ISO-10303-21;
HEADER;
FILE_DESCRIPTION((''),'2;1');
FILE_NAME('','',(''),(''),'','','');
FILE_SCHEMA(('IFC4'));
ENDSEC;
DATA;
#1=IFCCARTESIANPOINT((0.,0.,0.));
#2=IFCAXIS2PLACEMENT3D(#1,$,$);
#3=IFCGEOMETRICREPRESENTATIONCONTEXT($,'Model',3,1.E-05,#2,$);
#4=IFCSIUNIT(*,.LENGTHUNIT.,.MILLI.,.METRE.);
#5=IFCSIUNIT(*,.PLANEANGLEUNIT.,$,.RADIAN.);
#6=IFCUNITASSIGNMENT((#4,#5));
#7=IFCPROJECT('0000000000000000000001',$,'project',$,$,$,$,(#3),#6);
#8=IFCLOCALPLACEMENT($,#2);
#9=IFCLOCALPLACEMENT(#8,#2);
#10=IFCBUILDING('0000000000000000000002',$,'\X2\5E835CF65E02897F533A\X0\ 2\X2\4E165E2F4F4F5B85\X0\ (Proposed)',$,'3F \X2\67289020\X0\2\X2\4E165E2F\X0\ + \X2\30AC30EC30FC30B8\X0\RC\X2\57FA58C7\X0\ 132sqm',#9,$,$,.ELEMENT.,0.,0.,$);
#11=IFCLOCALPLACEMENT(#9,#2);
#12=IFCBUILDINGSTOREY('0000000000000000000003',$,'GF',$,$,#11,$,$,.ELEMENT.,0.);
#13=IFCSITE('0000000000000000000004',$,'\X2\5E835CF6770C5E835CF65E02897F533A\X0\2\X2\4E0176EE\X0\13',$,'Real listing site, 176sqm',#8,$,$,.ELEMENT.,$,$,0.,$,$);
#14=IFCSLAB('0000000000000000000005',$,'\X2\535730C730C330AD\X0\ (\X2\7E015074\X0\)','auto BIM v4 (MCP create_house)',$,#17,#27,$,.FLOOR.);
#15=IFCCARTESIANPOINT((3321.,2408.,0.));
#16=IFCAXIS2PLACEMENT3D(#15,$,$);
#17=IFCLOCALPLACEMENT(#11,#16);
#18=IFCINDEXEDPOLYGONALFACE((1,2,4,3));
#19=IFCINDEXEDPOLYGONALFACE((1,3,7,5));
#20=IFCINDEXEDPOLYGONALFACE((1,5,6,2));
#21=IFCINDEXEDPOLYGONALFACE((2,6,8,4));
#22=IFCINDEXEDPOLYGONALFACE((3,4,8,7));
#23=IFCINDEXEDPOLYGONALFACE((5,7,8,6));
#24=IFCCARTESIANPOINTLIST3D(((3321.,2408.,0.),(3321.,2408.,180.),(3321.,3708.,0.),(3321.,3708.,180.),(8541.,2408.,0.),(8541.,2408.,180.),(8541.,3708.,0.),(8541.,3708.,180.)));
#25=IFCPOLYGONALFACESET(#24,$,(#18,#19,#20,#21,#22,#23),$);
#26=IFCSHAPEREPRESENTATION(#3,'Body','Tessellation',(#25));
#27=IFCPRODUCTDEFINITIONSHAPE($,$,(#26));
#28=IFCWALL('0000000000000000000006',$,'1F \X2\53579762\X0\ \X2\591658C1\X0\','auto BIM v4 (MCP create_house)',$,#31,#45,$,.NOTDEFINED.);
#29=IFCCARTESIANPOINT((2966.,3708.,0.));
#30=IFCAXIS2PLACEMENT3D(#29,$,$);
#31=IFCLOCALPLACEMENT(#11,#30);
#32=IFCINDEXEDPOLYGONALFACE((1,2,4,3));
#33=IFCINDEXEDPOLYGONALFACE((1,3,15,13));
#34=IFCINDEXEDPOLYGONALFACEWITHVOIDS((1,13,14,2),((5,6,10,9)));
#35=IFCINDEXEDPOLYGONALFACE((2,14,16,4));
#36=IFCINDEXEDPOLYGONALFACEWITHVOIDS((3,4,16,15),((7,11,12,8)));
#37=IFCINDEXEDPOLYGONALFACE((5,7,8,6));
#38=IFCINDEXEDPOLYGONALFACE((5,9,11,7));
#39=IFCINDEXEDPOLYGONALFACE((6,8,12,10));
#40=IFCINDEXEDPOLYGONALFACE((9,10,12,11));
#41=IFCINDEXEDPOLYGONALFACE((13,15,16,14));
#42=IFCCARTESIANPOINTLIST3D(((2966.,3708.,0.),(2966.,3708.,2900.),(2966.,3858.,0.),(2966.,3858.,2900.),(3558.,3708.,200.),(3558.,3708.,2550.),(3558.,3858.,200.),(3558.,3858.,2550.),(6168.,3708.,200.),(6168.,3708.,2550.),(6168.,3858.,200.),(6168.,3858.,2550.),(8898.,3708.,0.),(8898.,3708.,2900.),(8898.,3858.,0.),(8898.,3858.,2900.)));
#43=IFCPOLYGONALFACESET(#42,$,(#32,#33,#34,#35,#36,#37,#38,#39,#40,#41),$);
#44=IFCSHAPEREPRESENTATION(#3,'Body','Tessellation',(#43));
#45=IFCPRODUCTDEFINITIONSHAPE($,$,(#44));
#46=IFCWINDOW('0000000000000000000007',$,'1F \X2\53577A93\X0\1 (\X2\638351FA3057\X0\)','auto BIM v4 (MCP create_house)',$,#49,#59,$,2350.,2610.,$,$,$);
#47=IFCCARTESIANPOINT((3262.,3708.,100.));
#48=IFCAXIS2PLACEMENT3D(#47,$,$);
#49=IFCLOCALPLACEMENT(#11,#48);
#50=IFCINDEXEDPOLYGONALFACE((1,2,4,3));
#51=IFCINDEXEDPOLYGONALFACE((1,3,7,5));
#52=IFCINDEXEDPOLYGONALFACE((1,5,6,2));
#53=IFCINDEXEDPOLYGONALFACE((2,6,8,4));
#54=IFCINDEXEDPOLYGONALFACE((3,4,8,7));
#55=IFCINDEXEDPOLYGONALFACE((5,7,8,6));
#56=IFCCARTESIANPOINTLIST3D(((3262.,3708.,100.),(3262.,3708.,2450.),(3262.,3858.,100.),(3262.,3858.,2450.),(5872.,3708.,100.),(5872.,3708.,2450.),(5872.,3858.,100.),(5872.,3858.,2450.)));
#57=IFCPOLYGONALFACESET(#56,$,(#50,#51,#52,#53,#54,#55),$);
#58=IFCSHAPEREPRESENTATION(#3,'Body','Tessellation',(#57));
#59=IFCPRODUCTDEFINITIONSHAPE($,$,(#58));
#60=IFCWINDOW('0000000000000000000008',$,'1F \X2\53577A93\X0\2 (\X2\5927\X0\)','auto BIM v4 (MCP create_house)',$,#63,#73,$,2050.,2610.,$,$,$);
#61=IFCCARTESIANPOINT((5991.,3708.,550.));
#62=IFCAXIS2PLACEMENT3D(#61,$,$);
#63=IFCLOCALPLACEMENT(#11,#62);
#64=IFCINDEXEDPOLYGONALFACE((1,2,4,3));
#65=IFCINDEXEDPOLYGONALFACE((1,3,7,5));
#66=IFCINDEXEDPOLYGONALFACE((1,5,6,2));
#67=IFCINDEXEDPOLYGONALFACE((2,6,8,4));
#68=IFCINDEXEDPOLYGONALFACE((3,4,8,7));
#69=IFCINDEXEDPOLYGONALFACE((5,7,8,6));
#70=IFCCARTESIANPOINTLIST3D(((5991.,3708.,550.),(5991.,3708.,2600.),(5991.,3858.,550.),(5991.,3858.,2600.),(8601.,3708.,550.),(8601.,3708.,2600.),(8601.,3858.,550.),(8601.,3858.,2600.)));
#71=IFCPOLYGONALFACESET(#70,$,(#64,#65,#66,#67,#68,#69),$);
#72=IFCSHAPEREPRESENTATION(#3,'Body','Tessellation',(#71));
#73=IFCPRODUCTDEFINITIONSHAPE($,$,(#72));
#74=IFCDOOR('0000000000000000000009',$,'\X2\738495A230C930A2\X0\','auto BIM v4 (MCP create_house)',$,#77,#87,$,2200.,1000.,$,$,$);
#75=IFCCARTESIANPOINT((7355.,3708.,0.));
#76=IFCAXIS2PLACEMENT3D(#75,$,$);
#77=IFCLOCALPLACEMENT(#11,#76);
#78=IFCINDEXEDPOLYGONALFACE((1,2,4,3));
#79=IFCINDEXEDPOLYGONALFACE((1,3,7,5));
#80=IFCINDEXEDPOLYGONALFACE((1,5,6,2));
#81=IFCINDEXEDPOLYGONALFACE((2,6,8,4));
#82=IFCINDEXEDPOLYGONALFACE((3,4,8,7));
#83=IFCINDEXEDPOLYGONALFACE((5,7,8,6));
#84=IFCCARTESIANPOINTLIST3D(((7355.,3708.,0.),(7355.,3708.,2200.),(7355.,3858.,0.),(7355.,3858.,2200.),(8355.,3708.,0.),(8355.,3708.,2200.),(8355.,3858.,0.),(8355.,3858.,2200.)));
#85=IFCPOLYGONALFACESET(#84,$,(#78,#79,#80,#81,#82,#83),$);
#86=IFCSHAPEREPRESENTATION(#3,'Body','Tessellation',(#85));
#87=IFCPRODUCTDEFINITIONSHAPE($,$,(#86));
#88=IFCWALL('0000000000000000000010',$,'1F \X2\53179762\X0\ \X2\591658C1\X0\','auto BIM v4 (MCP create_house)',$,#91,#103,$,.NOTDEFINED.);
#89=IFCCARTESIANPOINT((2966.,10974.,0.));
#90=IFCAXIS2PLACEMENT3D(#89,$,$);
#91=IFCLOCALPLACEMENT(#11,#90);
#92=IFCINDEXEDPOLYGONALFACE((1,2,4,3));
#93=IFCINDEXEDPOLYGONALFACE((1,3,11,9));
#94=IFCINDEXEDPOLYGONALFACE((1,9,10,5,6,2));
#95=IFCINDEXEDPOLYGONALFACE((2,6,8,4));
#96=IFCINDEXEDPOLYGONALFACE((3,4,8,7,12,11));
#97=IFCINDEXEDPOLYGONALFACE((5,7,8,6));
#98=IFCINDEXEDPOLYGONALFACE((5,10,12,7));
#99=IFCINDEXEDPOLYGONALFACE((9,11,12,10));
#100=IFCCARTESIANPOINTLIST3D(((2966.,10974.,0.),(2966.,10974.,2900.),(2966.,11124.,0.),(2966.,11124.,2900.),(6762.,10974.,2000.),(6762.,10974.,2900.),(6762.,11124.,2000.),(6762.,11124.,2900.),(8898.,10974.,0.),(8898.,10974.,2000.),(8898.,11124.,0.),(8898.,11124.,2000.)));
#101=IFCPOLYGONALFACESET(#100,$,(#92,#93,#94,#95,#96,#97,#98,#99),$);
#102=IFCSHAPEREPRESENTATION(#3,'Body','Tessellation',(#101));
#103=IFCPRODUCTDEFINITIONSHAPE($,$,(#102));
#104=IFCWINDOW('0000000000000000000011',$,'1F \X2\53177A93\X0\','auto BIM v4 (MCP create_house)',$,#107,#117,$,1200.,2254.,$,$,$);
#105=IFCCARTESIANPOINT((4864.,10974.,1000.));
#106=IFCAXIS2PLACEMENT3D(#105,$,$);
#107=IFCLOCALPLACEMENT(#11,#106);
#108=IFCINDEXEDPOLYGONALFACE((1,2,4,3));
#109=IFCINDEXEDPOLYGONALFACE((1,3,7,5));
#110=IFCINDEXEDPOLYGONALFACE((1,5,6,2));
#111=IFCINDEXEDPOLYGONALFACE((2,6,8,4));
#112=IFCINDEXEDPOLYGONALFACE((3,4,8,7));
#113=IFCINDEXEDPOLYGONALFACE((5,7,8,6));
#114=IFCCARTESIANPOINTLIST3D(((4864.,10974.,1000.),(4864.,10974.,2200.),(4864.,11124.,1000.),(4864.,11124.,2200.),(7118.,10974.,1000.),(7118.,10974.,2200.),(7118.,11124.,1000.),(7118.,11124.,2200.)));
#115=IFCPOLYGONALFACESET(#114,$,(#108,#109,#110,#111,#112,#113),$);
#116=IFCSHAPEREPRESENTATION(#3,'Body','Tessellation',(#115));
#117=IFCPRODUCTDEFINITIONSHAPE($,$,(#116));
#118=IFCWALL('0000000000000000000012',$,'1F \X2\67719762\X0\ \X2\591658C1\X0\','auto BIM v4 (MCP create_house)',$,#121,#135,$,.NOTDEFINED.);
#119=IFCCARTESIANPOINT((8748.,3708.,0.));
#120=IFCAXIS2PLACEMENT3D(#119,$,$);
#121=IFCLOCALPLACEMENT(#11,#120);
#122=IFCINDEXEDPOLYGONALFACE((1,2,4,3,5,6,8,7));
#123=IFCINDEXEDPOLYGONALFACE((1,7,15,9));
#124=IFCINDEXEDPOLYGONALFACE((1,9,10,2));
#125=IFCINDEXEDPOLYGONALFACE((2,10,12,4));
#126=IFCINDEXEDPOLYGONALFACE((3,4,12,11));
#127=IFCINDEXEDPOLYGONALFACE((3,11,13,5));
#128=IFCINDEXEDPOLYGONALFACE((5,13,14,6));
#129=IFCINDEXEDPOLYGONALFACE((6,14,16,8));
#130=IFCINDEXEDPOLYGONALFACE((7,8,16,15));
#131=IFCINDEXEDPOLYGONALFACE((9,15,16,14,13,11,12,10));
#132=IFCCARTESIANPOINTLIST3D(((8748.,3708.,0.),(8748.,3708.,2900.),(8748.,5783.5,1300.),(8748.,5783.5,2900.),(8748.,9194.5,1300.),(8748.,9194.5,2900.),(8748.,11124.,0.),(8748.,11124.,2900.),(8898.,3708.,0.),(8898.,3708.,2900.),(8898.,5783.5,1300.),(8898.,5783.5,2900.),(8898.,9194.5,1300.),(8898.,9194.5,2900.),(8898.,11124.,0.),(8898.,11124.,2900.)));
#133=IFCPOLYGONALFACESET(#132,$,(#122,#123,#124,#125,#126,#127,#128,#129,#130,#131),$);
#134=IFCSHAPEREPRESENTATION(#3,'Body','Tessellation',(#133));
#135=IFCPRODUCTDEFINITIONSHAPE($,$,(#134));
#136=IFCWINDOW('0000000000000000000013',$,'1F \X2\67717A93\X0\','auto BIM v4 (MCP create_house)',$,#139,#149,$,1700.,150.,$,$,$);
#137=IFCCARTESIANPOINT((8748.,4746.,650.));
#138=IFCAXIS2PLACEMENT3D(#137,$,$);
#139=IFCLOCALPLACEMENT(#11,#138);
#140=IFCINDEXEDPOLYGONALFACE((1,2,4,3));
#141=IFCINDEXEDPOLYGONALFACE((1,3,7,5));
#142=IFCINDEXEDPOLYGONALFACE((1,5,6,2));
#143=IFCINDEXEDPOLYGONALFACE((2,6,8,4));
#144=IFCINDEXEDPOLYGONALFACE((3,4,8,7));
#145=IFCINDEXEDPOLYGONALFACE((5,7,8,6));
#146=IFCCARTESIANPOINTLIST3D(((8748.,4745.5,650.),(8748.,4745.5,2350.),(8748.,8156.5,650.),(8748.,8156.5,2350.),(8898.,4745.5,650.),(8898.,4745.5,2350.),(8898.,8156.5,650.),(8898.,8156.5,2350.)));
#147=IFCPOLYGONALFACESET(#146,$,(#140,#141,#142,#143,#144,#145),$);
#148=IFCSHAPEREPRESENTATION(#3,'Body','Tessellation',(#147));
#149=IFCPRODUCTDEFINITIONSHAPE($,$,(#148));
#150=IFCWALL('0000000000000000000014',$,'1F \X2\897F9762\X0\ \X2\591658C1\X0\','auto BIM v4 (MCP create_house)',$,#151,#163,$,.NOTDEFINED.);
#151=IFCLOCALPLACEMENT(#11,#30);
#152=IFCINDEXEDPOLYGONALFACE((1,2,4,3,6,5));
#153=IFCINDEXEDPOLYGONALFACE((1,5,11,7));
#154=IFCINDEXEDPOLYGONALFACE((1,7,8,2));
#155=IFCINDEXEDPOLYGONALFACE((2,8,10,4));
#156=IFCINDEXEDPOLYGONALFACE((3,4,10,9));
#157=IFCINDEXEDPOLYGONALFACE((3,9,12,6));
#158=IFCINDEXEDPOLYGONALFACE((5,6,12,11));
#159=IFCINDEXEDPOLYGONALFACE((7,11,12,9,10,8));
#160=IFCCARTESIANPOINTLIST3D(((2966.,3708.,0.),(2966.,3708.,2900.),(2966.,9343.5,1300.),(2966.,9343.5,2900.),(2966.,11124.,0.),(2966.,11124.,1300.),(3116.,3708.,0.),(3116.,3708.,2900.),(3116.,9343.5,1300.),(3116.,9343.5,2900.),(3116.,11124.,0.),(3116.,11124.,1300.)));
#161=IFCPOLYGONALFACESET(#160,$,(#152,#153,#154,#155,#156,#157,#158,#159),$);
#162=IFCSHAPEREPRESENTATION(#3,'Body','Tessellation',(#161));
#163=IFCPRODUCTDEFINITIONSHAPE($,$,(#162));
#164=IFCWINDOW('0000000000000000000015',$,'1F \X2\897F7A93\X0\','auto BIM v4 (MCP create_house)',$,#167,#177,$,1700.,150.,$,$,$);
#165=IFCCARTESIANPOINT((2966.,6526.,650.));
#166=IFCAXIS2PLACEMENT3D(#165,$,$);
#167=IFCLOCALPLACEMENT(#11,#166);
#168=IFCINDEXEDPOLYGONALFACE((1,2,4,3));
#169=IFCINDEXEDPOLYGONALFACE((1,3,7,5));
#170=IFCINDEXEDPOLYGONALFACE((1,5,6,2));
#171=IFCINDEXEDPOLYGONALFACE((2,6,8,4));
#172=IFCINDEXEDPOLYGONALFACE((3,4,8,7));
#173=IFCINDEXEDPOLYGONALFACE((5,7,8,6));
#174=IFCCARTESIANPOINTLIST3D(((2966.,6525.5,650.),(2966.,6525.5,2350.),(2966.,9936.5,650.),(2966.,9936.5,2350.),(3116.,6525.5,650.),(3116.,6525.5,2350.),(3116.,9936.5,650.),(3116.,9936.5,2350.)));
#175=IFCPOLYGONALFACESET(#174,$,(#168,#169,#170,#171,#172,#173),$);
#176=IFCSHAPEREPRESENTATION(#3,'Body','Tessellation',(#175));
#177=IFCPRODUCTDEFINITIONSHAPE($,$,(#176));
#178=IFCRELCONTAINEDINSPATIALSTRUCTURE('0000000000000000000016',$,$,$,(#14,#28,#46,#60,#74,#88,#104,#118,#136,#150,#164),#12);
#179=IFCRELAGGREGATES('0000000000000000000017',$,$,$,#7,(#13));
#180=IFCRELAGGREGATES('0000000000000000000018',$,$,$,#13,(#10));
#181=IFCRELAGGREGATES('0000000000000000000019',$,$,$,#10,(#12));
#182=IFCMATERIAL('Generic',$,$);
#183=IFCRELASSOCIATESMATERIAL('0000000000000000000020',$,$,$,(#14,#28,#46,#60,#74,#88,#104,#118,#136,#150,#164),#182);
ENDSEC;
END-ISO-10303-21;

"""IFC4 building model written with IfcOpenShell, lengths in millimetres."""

from ifc_helpers import new_model, si_unit, frame, frame_2d, origin, place, context, project, spatial, rectangle, extrude, material, element, fill, save


model = new_model("IFC4")

# Units and contexts
model_context = context("Model", 3, precision=1e-05, world=origin())
ifc_project = project(units=[si_unit("LENGTHUNIT", "METRE", prefix="MILLI"), si_unit("PLANEANGLEUNIT", "RADIAN")], contexts=[model_context])

# Site, building, storey
site_placement = place(None, origin())
site = spatial("IfcSite", under=ifc_project, at=site_placement, Name="広島県広島市西区2丁目13", ObjectType="Real listing site, 176sqm", CompositionType="ELEMENT", RefElevation=0.0)
building_placement = place(site_placement, origin())
building = spatial("IfcBuilding", under=site, at=building_placement, Name="広島市西区 2世帯住宅 (Proposed)", ObjectType="3F 木造2世帯 + ガレージRC基壇 132sqm", CompositionType="ELEMENT", ElevationOfRefHeight=0.0, ElevationOfTerrain=0.0)
storey_placement = place(building_placement, origin())
storey = spatial("IfcBuildingStorey", under=building, at=storey_placement, Name="GF", CompositionType="ELEMENT", Elevation=0.0)

# Slab
ifc_material = material(Name="Generic")
slab_1_placement = place(storey_placement, frame((3321.0, 2408.0, 0.0)))
element("IfcSlab", 1, at=slab_1_placement, inside=storey, material=ifc_material, Name="南デッキ (縁側)", Description="auto BIM v4 (MCP create_house)", PredefinedType="FLOOR", context=model_context, shape_type="SweptSolid", body=[
    extrude(rectangle(XDim=5220.0, YDim=1300.0, at=frame_2d((2610.0, 650.0))), frame((3321.0, 2408.0, 0.0)), (0.0, 0.0, 1.0), 180.0),
])

# Wall, openings, windows, door
wall_1_placement = place(storey_placement, frame((2966.0, 3708.0, 0.0)))
wall_1 = element("IfcWall", 2, at=wall_1_placement, inside=storey, material=ifc_material, Name="1F 南面 外壁", Description="auto BIM v4 (MCP create_house)", PredefinedType="NOTDEFINED", context=model_context, shape_type="SweptSolid", body=[
    extrude(rectangle(XDim=5932.0, YDim=150.0, at=frame_2d((2966.0, 75.0))), frame((2966.0, 3708.0, 0.0)), (0.0, 0.0, 1.0), 2900.0),
])
opening_1_placement = place(storey_placement, frame((3262.0, 3708.0, 100.0)))
opening_1 = element("IfcOpeningElement", 3, at=opening_1_placement, cuts=wall_1, PredefinedType="NOTDEFINED", context=model_context, shape_type="SweptSolid", body=[
    extrude(rectangle(XDim=2610.0, YDim=150.0, at=frame_2d((1305.0, 75.0))), frame((3262.0, 3708.0, 100.0)), (0.0, 0.0, 1.0), 2350.0),
])
opening_2_placement = place(storey_placement, frame((5991.0, 3708.0, 550.0)))
opening_2 = element("IfcOpeningElement", 4, at=opening_2_placement, cuts=wall_1, PredefinedType="NOTDEFINED", context=model_context, shape_type="SweptSolid", body=[
    extrude(rectangle(XDim=2610.0, YDim=150.0, at=frame_2d((1305.0, 75.0))), frame((5991.0, 3708.0, 550.0)), (0.0, 0.0, 1.0), 2050.0),
])
opening_3_placement = place(storey_placement, frame((7355.0, 3708.0, 0.0)))
opening_3 = element("IfcOpeningElement", 5, at=opening_3_placement, cuts=wall_1, PredefinedType="NOTDEFINED", context=model_context, shape_type="SweptSolid", body=[
    extrude(rectangle(XDim=1000.0, YDim=150.0, at=frame_2d((500.0, 75.0))), frame((7355.0, 3708.0, 0.0)), (0.0, 0.0, 1.0), 2200.0),
])
window_1_placement = place(storey_placement, frame((3262.0, 3708.0, 100.0)))
window_1 = element("IfcWindow", 6, at=window_1_placement, inside=storey, material=ifc_material, Name="1F 南窓1 (掃出し)", Description="auto BIM v4 (MCP create_house)", OverallHeight=2350.0, OverallWidth=2610.0, context=model_context, shape_type="SweptSolid", body=[
    extrude(rectangle(XDim=2610.0, YDim=150.0, at=frame_2d((1305.0, 75.0))), frame((3262.0, 3708.0, 100.0)), (0.0, 0.0, 1.0), 2350.0),
])
fill(opening_1, window_1)
window_2_placement = place(storey_placement, frame((5991.0, 3708.0, 550.0)))
window_2 = element("IfcWindow", 7, at=window_2_placement, inside=storey, material=ifc_material, Name="1F 南窓2 (大)", Description="auto BIM v4 (MCP create_house)", OverallHeight=2050.0, OverallWidth=2610.0, context=model_context, shape_type="SweptSolid", body=[
    extrude(rectangle(XDim=2610.0, YDim=150.0, at=frame_2d((1305.0, 75.0))), frame((5991.0, 3708.0, 550.0)), (0.0, 0.0, 1.0), 2050.0),
])
fill(opening_2, window_2)
door_placement = place(storey_placement, frame((7355.0, 3708.0, 0.0)))
door = element("IfcDoor", 8, at=door_placement, inside=storey, material=ifc_material, Name="玄関ドア", Description="auto BIM v4 (MCP create_house)", OverallHeight=2200.0, OverallWidth=1000.0, context=model_context, shape_type="SweptSolid", body=[
    extrude(rectangle(XDim=1000.0, YDim=150.0, at=frame_2d((500.0, 75.0))), frame((7355.0, 3708.0, 0.0)), (0.0, 0.0, 1.0), 2200.0),
])
fill(opening_3, door)

# Walls, openings, windows
wall_2_placement = place(storey_placement, frame((2966.0, 10974.0, 0.0)))
wall_2 = element("IfcWall", 9, at=wall_2_placement, inside=storey, material=ifc_material, Name="1F 北面 外壁", Description="auto BIM v4 (MCP create_house)", PredefinedType="NOTDEFINED", context=model_context, shape_type="SweptSolid", body=[
    extrude(rectangle(XDim=5932.0, YDim=150.0, at=frame_2d((2966.0, 75.0))), frame((2966.0, 10974.0, 0.0)), (0.0, 0.0, 1.0), 2900.0),
])
opening_4_placement = place(storey_placement, frame((4864.0, 10974.0, 1000.0)))
opening_4 = element("IfcOpeningElement", 10, at=opening_4_placement, cuts=wall_2, PredefinedType="NOTDEFINED", context=model_context, shape_type="SweptSolid", body=[
    extrude(rectangle(XDim=2254.0, YDim=150.0, at=frame_2d((1127.0, 75.0))), frame((4864.0, 10974.0, 1000.0)), (0.0, 0.0, 1.0), 1200.0),
])
window_3_placement = place(storey_placement, frame((4864.0, 10974.0, 1000.0)))
window_3 = element("IfcWindow", 11, at=window_3_placement, inside=storey, material=ifc_material, Name="1F 北窓", Description="auto BIM v4 (MCP create_house)", OverallHeight=1200.0, OverallWidth=2254.0, context=model_context, shape_type="SweptSolid", body=[
    extrude(rectangle(XDim=2254.0, YDim=150.0, at=frame_2d((1127.0, 75.0))), frame((4864.0, 10974.0, 1000.0)), (0.0, 0.0, 1.0), 1200.0),
])
fill(opening_4, window_3)
wall_3_placement = place(storey_placement, frame((8748.0, 3708.0, 0.0)))
wall_3 = element("IfcWall", 12, at=wall_3_placement, inside=storey, material=ifc_material, Name="1F 東面 外壁", Description="auto BIM v4 (MCP create_house)", PredefinedType="NOTDEFINED", context=model_context, shape_type="SweptSolid", body=[
    extrude(rectangle(XDim=150.0, YDim=7416.0, at=frame_2d((75.0, 3708.0))), frame((8748.0, 3708.0, 0.0)), (0.0, 0.0, 1.0), 2900.0),
])
opening_5_placement = place(storey_placement, frame((8748.0, 4746.0, 650.0)))
opening_5 = element("IfcOpeningElement", 13, at=opening_5_placement, cuts=wall_3, PredefinedType="NOTDEFINED", context=model_context, shape_type="SweptSolid", body=[
    extrude(rectangle(XDim=150.0, YDim=3411.0, at=frame_2d((75.0, 1705.0))), frame((8748.0, 4746.0, 650.0)), (0.0, 0.0, 1.0), 1700.0),
])
window_4_placement = place(storey_placement, frame((8748.0, 4746.0, 650.0)))
window_4 = element("IfcWindow", 14, at=window_4_placement, inside=storey, material=ifc_material, Name="1F 東窓", Description="auto BIM v4 (MCP create_house)", OverallHeight=1700.0, OverallWidth=150.0, context=model_context, shape_type="SweptSolid", body=[
    extrude(rectangle(XDim=150.0, YDim=3411.0, at=frame_2d((75.0, 1705.0))), frame((8748.0, 4746.0, 650.0)), (0.0, 0.0, 1.0), 1700.0),
])
fill(opening_5, window_4)
wall_4_placement = place(storey_placement, frame((2966.0, 3708.0, 0.0)))
wall_4 = element("IfcWall", 15, at=wall_4_placement, inside=storey, material=ifc_material, Name="1F 西面 外壁", Description="auto BIM v4 (MCP create_house)", PredefinedType="NOTDEFINED", context=model_context, shape_type="SweptSolid", body=[
    extrude(rectangle(XDim=150.0, YDim=7416.0, at=frame_2d((75.0, 3708.0))), frame((2966.0, 3708.0, 0.0)), (0.0, 0.0, 1.0), 2900.0),
])
opening_6_placement = place(storey_placement, frame((2966.0, 6526.0, 650.0)))
opening_6 = element("IfcOpeningElement", 16, at=opening_6_placement, cuts=wall_4, PredefinedType="NOTDEFINED", context=model_context, shape_type="SweptSolid", body=[
    extrude(rectangle(XDim=150.0, YDim=3411.0, at=frame_2d((75.0, 1705.0))), frame((2966.0, 6526.0, 650.0)), (0.0, 0.0, 1.0), 1700.0),
])
window_5_placement = place(storey_placement, frame((2966.0, 6526.0, 650.0)))
window_5 = element("IfcWindow", 17, at=window_5_placement, inside=storey, material=ifc_material, Name="1F 西窓", Description="auto BIM v4 (MCP create_house)", OverallHeight=1700.0, OverallWidth=150.0, context=model_context, shape_type="SweptSolid", body=[
    extrude(rectangle(XDim=150.0, YDim=3411.0, at=frame_2d((75.0, 1705.0))), frame((2966.0, 6526.0, 650.0)), (0.0, 0.0, 1.0), 1700.0),
])
fill(opening_6, window_5)

save(model, "model.ifc")
